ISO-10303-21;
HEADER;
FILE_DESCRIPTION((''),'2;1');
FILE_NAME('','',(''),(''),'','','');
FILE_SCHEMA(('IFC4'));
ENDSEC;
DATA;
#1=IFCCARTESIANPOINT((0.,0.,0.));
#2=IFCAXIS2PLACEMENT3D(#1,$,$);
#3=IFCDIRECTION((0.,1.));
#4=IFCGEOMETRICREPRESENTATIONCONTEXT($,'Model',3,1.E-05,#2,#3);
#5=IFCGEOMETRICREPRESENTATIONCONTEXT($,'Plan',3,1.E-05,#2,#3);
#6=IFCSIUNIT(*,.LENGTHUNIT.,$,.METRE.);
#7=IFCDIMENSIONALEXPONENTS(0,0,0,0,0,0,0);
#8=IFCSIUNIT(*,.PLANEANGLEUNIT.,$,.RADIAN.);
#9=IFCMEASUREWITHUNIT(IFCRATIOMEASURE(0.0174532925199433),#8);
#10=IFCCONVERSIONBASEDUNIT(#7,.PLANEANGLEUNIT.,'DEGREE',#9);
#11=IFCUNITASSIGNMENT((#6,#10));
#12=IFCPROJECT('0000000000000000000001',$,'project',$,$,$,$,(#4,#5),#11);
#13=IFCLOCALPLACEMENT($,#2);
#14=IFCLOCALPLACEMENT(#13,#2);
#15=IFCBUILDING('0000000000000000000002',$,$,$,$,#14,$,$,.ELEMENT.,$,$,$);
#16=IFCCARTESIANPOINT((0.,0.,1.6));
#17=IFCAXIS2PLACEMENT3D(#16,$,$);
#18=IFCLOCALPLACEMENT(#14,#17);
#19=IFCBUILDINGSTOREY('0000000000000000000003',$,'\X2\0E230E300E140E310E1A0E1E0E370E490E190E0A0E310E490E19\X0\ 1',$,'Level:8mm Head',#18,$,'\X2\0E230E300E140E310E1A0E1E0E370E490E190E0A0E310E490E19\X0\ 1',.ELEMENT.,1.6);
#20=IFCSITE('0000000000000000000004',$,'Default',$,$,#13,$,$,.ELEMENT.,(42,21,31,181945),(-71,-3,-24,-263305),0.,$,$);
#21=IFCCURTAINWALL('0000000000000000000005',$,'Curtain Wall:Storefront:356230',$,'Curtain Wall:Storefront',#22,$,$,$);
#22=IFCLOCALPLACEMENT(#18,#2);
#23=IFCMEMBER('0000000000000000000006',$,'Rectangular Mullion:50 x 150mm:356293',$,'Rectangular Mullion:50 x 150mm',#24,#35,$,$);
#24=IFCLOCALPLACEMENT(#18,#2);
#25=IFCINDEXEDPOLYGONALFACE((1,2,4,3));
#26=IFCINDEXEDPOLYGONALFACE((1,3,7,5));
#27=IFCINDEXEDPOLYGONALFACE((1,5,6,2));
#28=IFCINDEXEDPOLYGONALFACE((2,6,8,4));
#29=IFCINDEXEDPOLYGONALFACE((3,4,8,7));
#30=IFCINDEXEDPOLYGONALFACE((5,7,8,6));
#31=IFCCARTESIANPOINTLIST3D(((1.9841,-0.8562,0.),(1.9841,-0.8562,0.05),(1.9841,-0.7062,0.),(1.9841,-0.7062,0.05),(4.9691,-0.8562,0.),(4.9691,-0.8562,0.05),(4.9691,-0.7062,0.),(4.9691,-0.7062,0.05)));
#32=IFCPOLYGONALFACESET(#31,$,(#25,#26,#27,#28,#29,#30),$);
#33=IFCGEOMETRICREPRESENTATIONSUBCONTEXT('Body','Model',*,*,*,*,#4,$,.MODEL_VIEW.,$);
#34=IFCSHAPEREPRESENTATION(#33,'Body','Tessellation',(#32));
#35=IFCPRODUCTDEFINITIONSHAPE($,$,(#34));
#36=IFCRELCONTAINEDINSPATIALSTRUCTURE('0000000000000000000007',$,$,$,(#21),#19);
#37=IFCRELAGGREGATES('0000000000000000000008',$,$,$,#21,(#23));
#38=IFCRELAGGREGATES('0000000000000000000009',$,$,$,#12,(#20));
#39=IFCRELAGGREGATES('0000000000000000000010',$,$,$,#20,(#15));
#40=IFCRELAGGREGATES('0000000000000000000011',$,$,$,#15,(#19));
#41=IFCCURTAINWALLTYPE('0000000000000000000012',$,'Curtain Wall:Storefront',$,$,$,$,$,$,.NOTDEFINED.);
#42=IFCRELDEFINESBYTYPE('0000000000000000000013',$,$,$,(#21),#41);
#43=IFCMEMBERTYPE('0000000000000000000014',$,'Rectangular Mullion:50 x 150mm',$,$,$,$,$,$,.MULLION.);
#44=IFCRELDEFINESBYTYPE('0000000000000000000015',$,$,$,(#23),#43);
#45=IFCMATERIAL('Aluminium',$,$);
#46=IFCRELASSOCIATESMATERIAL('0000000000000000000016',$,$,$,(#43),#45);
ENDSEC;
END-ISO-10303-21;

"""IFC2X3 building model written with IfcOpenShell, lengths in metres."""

from ifc_helpers import new_model, entity, si_unit, converted_unit, direction, frame, origin, origin_2d_with_axis, place, context, subcontext, project, spatial, rectangle, extrude, source, transform, mapped, material, type_object, type_shapes, element, aggregate, save


model = new_model("IFC2X3")

# Units and contexts
model_context = context("Model", 3, precision=1e-05, world=origin(), true_north=direction((0.0, 1.0)))
plan_context = context("Plan", 3, precision=1e-05, world=origin(), true_north=direction((0.0, 1.0)))
body_context = subcontext(model_context, "Body", "Model", "MODEL_VIEW")
ifc_project = project(units=[si_unit("LENGTHUNIT", "METRE"), converted_unit("PLANEANGLEUNIT", "DEGREE", entity("IfcRatioMeasure", 0.0174532925199433), si_unit("PLANEANGLEUNIT", "RADIAN"), dimensions=[0, 0, 0, 0, 0, 0, 0])], contexts=[model_context, plan_context])

# Site, building, storey
site_placement = place(None, origin())
site = spatial("IfcSite", under=ifc_project, at=site_placement, Name="Default", CompositionType="ELEMENT", RefLatitude=(42, 21, 31, 181945), RefLongitude=(-71, -3, -24, -263305), RefElevation=0.0)
building_placement = place(site_placement, origin())
building = spatial("IfcBuilding", under=site, at=building_placement, CompositionType="ELEMENT")
storey_placement = place(building_placement, frame((0.0, 0.0, 1.6)))
storey = spatial("IfcBuildingStorey", under=building, at=storey_placement, Name="ระดับพื้นชั้น 1", ObjectType="Level:8mm Head", LongName="ระดับพื้นชั้น 1", CompositionType="ELEMENT", Elevation=1.6)

# Shared definitions
curtain_wall_type = type_object("IfcCurtainWallType", Name="Curtain Wall:Storefront", PredefinedType="NOTDEFINED")
ifc_material_1 = material(Name="Aluminium")

# Curtain wall
curtain_wall_1_placement = place(storey_placement, frame((0.0, 0.0, -1.6)))
curtain_wall_1 = element("IfcCurtainWall", 1, at=curtain_wall_1_placement, inside=storey, type_object=curtain_wall_type, Name="Curtain Wall:Storefront:356230", ObjectType="Curtain Wall:Storefront")

# Member
member_type_1 = type_object("IfcMemberType", Name="Rectangular Mullion:50 x 150mm", PredefinedType="MULLION", material=ifc_material_1)
shared_shape_1 = source(origin(), body_context, "Body", "SweptSolid", [
    extrude(rectangle(XDim=0.15, YDim=0.05, at=origin_2d_with_axis()), frame((-0.025, 0.0, -2.985), z_axis=(0.0, 0.0, 1.0), x_axis=(0.0, -1.0, 0.0)), (0.0, 0.0, 1.0), 2.985),
])
type_shapes(member_type_1, [shared_shape_1])
member_1_placement = place(curtain_wall_1_placement, frame((4.9691, -0.7812, 1.6), z_axis=(1.0, 0.0, 0.0), x_axis=(0.0, 0.0, -1.0)))
member_1 = element("IfcMember", 2, at=member_1_placement, type_object=member_type_1, Name="Rectangular Mullion:50 x 150mm:356293", ObjectType="Rectangular Mullion:50 x 150mm", context=body_context, shape_type="MappedRepresentation", body=[
    mapped(shared_shape_1, transform((0.0, 0.0, 0.0), scale=1.0)),
])

aggregate(curtain_wall_1, [member_1])

save(model, "model.ifc")
